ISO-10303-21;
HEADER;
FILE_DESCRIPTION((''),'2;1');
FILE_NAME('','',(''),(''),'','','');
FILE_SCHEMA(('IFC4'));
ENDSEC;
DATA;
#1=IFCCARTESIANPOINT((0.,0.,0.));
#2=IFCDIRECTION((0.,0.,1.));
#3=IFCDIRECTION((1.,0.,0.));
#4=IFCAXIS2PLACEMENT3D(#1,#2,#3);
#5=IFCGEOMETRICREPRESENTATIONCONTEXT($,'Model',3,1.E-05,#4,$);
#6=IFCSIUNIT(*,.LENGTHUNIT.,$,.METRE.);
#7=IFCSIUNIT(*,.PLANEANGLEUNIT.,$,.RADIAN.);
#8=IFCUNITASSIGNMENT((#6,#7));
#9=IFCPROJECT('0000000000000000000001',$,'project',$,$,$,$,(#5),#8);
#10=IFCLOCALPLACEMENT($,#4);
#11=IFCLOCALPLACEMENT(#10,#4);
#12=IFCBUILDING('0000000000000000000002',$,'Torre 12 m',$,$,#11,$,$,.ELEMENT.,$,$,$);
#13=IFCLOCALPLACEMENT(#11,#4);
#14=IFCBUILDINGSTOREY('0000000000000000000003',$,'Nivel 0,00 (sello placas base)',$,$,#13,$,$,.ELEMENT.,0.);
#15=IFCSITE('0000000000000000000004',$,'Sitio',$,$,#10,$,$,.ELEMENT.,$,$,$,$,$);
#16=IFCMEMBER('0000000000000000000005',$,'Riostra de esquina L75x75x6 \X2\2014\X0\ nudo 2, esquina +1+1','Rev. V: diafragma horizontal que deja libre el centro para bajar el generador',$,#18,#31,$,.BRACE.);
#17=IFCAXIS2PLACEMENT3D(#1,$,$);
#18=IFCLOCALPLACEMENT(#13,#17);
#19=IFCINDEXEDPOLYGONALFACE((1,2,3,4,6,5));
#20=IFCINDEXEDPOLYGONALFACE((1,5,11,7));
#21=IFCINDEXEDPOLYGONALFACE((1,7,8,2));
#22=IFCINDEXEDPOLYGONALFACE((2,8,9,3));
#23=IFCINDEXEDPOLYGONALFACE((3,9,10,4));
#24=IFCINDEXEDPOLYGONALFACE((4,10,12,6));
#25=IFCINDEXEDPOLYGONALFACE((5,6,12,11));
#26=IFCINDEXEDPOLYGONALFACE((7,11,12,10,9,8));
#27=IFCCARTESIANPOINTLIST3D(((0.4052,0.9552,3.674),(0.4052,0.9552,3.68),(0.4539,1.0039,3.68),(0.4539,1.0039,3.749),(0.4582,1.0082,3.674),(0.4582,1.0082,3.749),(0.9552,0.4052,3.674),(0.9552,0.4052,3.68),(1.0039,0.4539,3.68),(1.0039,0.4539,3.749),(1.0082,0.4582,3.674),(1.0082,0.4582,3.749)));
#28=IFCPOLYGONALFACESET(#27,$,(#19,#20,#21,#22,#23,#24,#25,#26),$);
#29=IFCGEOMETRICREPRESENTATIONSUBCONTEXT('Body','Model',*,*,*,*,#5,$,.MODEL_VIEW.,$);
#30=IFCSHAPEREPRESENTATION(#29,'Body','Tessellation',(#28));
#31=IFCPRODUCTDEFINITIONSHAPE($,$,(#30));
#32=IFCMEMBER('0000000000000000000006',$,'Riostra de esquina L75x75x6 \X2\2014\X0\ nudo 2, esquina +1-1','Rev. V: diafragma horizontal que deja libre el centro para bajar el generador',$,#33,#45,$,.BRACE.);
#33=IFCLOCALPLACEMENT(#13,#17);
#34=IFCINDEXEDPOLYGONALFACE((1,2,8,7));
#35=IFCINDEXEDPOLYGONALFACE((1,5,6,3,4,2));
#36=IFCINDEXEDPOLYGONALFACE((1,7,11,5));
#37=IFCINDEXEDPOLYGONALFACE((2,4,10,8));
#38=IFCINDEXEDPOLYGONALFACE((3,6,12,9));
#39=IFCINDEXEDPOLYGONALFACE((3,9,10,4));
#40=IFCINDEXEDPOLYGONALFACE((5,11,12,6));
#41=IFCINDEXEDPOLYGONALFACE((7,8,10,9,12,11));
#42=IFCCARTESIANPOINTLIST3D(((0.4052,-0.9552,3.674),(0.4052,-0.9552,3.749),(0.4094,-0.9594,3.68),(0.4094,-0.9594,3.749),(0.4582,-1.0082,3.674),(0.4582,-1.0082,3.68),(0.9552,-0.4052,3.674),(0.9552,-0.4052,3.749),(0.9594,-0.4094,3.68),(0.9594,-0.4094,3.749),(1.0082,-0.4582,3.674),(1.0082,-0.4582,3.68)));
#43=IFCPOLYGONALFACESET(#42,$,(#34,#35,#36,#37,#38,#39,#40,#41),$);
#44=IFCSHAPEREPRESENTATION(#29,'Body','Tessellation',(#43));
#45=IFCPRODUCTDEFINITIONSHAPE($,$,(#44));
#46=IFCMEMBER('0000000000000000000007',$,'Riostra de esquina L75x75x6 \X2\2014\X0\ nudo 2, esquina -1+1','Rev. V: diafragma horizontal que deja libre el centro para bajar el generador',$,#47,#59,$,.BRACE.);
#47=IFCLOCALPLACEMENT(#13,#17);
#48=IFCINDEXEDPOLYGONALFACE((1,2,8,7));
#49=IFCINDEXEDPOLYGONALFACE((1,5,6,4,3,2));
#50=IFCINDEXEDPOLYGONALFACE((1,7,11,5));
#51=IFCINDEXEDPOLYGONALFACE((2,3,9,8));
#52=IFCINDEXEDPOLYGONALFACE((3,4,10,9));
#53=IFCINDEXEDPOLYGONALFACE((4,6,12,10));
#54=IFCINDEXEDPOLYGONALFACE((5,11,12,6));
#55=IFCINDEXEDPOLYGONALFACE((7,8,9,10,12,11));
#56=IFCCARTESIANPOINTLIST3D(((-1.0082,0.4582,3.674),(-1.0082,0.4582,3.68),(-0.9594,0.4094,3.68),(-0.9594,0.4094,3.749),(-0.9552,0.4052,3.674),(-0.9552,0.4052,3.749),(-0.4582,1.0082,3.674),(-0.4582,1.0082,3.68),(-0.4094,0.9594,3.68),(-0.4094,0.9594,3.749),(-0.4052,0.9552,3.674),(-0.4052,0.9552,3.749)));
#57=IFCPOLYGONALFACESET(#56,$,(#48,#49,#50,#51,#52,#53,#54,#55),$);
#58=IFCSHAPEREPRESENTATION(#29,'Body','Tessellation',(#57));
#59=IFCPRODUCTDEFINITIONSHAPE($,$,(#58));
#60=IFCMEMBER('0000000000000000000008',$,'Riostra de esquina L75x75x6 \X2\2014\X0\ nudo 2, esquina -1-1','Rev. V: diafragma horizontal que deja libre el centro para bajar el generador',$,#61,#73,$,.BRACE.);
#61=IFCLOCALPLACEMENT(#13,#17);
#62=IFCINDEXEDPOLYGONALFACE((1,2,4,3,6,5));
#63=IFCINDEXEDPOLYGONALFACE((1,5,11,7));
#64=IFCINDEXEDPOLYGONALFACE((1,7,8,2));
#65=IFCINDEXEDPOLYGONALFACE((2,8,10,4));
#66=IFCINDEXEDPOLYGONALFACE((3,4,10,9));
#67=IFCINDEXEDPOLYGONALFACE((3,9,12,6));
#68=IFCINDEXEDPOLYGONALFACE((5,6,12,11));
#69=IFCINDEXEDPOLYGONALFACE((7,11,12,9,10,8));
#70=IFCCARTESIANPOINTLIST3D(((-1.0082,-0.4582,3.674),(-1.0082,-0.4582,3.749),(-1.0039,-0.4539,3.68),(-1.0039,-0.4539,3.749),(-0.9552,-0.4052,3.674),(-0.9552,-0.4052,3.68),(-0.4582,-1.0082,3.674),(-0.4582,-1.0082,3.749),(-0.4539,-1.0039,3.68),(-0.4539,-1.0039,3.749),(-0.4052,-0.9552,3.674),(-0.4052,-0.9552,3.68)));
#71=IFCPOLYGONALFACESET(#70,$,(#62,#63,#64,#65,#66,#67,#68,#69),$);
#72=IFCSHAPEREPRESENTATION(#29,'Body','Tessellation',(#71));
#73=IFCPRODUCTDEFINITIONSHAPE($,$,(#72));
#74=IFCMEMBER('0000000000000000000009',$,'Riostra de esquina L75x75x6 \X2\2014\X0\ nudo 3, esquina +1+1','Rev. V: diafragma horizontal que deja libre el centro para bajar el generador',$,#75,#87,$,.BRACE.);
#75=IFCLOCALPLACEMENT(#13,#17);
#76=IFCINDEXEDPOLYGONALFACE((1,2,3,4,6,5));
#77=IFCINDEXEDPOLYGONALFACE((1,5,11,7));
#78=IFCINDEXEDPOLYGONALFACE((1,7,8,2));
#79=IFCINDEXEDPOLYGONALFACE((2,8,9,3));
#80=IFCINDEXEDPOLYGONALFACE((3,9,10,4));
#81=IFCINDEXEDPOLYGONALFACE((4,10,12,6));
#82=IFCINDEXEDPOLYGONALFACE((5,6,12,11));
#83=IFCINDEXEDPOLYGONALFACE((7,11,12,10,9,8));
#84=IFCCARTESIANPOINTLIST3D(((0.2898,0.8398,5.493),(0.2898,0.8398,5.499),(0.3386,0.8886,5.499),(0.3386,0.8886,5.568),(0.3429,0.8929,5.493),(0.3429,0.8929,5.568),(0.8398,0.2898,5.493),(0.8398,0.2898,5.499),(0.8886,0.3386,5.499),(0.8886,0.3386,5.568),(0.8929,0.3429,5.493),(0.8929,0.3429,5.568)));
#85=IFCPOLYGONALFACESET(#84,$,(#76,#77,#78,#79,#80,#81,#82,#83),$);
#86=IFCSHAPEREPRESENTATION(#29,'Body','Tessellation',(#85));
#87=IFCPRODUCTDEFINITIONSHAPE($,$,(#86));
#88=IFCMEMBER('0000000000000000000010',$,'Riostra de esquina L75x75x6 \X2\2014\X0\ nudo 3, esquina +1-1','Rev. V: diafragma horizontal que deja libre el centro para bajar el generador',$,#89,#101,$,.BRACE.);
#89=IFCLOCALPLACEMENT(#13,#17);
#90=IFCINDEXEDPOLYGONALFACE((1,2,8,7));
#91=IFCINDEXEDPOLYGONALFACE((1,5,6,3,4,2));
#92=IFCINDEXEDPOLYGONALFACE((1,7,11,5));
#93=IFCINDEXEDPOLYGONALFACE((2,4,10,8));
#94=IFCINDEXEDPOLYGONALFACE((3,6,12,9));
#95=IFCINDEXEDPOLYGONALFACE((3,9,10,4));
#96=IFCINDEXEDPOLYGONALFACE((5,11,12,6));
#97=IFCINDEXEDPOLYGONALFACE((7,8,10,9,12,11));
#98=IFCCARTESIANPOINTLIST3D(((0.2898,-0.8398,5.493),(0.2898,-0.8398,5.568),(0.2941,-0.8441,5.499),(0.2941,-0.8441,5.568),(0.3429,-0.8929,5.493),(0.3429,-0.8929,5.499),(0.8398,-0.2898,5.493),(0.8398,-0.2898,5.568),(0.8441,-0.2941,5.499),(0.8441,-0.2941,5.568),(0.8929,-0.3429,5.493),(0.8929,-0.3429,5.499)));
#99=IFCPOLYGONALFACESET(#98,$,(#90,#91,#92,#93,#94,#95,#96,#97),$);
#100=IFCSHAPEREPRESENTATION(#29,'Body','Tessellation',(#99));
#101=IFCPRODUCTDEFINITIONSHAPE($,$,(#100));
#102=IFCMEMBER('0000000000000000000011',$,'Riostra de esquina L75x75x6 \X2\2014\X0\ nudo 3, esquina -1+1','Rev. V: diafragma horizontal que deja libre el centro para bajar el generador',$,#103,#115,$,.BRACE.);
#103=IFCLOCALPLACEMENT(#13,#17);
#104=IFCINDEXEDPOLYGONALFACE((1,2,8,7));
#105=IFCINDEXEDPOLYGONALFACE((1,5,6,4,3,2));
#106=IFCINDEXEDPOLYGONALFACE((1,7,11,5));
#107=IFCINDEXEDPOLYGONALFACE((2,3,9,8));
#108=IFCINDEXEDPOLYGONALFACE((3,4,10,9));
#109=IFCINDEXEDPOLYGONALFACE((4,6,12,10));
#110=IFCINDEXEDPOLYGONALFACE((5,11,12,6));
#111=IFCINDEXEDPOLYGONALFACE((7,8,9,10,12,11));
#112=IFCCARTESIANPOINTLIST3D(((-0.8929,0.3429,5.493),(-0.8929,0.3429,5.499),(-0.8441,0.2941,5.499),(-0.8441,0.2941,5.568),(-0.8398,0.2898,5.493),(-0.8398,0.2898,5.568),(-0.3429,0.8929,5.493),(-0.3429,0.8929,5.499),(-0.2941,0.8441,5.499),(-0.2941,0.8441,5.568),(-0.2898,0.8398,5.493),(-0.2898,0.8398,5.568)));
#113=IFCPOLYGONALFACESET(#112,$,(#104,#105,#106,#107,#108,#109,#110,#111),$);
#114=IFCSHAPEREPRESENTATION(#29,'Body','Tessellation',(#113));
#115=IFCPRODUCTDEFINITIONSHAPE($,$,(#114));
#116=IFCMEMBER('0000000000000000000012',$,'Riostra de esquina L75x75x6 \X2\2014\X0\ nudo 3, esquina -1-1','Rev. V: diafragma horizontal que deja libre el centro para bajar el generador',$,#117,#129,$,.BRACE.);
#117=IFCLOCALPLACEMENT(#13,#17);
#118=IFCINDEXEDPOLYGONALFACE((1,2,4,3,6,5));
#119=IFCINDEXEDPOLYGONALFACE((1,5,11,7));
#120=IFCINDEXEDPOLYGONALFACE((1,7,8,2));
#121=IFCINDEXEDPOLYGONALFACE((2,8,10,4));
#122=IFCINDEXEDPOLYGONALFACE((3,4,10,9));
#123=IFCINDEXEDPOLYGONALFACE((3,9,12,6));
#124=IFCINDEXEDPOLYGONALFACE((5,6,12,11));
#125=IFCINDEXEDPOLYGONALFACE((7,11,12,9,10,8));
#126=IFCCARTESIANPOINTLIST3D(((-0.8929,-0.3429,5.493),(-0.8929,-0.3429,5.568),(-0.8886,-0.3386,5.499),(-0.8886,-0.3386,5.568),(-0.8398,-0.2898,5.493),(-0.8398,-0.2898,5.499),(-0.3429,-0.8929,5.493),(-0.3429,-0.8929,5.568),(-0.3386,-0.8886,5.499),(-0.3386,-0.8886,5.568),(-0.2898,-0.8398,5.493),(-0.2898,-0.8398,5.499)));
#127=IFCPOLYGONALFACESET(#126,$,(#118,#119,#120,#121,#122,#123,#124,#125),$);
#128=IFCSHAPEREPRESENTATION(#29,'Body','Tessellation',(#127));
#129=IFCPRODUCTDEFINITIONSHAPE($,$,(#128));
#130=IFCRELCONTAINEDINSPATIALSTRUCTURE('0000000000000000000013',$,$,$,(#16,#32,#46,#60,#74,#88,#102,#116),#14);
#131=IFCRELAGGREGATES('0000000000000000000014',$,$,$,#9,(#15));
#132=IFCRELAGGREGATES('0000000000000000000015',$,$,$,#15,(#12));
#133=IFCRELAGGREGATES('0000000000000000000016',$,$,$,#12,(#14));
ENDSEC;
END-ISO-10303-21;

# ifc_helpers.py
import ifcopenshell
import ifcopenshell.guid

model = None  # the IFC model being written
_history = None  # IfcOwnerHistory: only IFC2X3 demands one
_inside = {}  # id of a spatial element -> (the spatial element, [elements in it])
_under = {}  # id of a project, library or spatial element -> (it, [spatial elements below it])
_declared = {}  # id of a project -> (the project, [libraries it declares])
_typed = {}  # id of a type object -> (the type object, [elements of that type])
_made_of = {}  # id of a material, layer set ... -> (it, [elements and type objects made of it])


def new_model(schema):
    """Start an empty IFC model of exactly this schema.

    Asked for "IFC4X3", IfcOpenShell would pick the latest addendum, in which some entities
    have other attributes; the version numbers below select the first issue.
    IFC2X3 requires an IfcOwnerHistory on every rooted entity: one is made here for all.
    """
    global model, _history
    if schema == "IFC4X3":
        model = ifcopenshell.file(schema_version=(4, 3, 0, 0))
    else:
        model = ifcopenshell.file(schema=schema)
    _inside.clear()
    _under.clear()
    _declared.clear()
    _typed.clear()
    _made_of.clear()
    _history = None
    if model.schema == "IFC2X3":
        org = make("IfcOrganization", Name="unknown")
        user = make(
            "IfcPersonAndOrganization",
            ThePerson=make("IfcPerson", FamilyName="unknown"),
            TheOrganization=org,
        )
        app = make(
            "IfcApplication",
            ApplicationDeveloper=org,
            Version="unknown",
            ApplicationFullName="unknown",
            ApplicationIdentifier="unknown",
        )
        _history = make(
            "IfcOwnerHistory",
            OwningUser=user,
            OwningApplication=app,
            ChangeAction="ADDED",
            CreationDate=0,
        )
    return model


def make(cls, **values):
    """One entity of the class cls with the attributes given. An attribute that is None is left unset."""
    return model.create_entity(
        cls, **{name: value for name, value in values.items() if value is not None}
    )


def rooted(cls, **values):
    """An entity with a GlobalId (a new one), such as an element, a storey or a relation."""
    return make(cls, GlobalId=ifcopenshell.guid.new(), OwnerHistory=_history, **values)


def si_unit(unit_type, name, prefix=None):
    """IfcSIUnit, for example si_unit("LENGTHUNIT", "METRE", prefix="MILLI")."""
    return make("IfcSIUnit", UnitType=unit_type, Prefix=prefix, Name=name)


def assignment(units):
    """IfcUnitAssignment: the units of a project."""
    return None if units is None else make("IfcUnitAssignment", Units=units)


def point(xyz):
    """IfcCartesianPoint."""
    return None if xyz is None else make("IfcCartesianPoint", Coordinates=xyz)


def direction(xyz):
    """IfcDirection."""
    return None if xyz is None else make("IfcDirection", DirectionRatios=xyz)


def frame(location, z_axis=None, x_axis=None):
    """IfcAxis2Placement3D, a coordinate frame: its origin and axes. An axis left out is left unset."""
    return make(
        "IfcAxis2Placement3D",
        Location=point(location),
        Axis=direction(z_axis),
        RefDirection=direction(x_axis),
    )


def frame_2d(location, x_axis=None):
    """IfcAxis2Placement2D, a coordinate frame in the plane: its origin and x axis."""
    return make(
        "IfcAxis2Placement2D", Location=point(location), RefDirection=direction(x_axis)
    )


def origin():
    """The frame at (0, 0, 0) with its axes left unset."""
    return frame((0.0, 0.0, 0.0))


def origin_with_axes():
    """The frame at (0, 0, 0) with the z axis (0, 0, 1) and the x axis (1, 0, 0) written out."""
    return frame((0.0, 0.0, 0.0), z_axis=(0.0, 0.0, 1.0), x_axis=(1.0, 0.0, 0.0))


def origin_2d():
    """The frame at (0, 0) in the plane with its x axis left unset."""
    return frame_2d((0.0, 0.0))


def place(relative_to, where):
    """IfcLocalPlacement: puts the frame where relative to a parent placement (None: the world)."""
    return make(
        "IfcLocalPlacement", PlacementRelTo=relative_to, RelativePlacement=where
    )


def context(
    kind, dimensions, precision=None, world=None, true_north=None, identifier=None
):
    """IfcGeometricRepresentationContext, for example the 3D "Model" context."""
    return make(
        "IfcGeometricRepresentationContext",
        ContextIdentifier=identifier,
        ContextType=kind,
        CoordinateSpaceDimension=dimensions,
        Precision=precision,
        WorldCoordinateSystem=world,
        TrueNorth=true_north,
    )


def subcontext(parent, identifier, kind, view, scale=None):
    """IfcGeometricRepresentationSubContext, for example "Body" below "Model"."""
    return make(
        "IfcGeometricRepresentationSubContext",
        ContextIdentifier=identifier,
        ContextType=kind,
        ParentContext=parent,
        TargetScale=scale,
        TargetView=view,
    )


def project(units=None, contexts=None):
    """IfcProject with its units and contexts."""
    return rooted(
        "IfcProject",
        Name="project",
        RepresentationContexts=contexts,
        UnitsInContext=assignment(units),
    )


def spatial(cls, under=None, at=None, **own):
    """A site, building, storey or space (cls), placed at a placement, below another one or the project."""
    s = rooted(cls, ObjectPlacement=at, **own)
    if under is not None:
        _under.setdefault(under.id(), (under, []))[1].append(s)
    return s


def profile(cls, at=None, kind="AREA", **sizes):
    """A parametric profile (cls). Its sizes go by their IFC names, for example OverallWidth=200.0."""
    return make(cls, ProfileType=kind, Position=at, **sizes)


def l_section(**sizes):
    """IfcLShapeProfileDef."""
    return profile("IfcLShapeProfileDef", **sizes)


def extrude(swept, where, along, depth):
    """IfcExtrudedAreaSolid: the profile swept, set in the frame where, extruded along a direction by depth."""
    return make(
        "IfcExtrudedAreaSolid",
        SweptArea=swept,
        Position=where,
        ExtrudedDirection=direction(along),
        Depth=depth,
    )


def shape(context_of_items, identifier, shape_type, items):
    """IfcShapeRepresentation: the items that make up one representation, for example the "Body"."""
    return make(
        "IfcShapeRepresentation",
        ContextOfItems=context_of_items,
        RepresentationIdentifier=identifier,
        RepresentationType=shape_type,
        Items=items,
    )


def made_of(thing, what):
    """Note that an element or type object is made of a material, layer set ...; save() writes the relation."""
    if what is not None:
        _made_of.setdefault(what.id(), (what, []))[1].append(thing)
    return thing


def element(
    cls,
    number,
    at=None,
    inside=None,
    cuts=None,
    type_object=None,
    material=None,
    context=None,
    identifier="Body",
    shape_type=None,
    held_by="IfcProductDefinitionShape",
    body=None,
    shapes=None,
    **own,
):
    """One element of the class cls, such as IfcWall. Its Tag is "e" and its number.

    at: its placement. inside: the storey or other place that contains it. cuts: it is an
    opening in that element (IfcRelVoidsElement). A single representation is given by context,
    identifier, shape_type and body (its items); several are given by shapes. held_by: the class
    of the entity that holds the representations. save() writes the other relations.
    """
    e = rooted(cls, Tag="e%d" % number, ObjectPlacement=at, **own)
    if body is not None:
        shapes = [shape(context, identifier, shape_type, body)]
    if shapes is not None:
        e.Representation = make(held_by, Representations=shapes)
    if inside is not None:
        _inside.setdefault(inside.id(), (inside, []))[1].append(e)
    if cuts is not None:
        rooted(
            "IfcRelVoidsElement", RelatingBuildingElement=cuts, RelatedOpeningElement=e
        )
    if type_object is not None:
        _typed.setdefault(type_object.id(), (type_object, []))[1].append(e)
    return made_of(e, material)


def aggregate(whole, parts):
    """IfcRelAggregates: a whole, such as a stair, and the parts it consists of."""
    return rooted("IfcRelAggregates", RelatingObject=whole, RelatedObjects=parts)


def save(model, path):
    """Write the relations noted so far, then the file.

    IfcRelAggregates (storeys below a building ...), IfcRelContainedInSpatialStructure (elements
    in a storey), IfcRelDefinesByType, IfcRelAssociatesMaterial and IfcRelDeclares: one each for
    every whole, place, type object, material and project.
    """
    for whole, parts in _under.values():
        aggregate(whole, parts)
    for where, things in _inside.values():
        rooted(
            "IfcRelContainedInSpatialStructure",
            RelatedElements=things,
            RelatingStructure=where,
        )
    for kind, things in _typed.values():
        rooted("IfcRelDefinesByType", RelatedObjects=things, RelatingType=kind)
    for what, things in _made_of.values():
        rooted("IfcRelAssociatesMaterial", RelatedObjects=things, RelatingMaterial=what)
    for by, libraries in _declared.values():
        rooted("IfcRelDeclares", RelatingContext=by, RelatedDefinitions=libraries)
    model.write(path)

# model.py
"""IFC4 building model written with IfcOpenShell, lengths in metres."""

from ifc_helpers import new_model, si_unit, frame, origin, origin_with_axes, origin_2d, place, context, subcontext, project, spatial, l_section, extrude, element, save


model = new_model("IFC4")

# Units and contexts
model_context = context("Model", 3, precision=1e-05, world=origin_with_axes())
body_context = subcontext(model_context, "Body", "Model", "MODEL_VIEW")
ifc_project = project(units=[si_unit("LENGTHUNIT", "METRE"), si_unit("PLANEANGLEUNIT", "RADIAN")], contexts=[model_context])

# Site, building, storey
site_placement = place(None, origin_with_axes())
site = spatial("IfcSite", under=ifc_project, at=site_placement, Name="Sitio", CompositionType="ELEMENT")
building_placement = place(site_placement, origin_with_axes())
building = spatial("IfcBuilding", under=site, at=building_placement, Name="Torre 12 m", CompositionType="ELEMENT")
storey_placement = place(building_placement, origin_with_axes())
storey = spatial("IfcBuildingStorey", under=building, at=storey_placement, Name="Nivel 0,00 (sello placas base)", CompositionType="ELEMENT", Elevation=0.0)

# Members
for number, where, z_axis, x_axis, name in (
    (1, (0.4317, 0.9817, 3.7115), (0.707107, -0.707107, 0.0), (0.0, 0.0, 1.0), "Riostra de esquina L75x75x6 — nudo 2, esquina +1+1"),
    (2, (0.4317, -0.9817, 3.7115), (0.707107, 0.707107, 0.0), (0.0, 0.0, 1.0), "Riostra de esquina L75x75x6 — nudo 2, esquina +1-1"),
    (3, (-0.4317, 0.9817, 3.7115), (-0.707107, -0.707107, 0.0), (0.0, 0.0, 1.0), "Riostra de esquina L75x75x6 — nudo 2, esquina -1+1"),
    (4, (-0.4317, -0.9817, 3.7115), (-0.707107, 0.707107, 0.0), (0.0, 0.0, 1.0), "Riostra de esquina L75x75x6 — nudo 2, esquina -1-1"),
    (5, (0.3163, 0.8663, 5.5305), (0.707107, -0.707107, 0.0), (0.0, 0.0, 1.0), "Riostra de esquina L75x75x6 — nudo 3, esquina +1+1"),
    (6, (0.3163, -0.8663, 5.5305), (0.707107, 0.707107, 0.0), (0.0, 0.0, 1.0), "Riostra de esquina L75x75x6 — nudo 3, esquina +1-1"),
    (7, (-0.3163, 0.8663, 5.5305), (-0.707107, -0.707107, 0.0), (0.0, 0.0, 1.0), "Riostra de esquina L75x75x6 — nudo 3, esquina -1+1"),
    (8, (-0.3163, -0.8663, 5.5305), (-0.707107, 0.707107, 0.0), (0.0, 0.0, 1.0), "Riostra de esquina L75x75x6 — nudo 3, esquina -1-1"),
):
    element("IfcMember", number, at=place(storey_placement, frame(where, z_axis=z_axis, x_axis=x_axis)), inside=storey, Name=name, Description="Rev. V: diafragma horizontal que deja libre el centro para bajar el generador", PredefinedType="BRACE", context=body_context, shape_type="SweptSolid", body=[
        extrude(l_section(Depth=0.075, Width=0.075, Thickness=0.006, at=origin_2d()), origin(), (0.0, 0.0, 1.0), 0.7778),
    ])

save(model, "model.ifc")
